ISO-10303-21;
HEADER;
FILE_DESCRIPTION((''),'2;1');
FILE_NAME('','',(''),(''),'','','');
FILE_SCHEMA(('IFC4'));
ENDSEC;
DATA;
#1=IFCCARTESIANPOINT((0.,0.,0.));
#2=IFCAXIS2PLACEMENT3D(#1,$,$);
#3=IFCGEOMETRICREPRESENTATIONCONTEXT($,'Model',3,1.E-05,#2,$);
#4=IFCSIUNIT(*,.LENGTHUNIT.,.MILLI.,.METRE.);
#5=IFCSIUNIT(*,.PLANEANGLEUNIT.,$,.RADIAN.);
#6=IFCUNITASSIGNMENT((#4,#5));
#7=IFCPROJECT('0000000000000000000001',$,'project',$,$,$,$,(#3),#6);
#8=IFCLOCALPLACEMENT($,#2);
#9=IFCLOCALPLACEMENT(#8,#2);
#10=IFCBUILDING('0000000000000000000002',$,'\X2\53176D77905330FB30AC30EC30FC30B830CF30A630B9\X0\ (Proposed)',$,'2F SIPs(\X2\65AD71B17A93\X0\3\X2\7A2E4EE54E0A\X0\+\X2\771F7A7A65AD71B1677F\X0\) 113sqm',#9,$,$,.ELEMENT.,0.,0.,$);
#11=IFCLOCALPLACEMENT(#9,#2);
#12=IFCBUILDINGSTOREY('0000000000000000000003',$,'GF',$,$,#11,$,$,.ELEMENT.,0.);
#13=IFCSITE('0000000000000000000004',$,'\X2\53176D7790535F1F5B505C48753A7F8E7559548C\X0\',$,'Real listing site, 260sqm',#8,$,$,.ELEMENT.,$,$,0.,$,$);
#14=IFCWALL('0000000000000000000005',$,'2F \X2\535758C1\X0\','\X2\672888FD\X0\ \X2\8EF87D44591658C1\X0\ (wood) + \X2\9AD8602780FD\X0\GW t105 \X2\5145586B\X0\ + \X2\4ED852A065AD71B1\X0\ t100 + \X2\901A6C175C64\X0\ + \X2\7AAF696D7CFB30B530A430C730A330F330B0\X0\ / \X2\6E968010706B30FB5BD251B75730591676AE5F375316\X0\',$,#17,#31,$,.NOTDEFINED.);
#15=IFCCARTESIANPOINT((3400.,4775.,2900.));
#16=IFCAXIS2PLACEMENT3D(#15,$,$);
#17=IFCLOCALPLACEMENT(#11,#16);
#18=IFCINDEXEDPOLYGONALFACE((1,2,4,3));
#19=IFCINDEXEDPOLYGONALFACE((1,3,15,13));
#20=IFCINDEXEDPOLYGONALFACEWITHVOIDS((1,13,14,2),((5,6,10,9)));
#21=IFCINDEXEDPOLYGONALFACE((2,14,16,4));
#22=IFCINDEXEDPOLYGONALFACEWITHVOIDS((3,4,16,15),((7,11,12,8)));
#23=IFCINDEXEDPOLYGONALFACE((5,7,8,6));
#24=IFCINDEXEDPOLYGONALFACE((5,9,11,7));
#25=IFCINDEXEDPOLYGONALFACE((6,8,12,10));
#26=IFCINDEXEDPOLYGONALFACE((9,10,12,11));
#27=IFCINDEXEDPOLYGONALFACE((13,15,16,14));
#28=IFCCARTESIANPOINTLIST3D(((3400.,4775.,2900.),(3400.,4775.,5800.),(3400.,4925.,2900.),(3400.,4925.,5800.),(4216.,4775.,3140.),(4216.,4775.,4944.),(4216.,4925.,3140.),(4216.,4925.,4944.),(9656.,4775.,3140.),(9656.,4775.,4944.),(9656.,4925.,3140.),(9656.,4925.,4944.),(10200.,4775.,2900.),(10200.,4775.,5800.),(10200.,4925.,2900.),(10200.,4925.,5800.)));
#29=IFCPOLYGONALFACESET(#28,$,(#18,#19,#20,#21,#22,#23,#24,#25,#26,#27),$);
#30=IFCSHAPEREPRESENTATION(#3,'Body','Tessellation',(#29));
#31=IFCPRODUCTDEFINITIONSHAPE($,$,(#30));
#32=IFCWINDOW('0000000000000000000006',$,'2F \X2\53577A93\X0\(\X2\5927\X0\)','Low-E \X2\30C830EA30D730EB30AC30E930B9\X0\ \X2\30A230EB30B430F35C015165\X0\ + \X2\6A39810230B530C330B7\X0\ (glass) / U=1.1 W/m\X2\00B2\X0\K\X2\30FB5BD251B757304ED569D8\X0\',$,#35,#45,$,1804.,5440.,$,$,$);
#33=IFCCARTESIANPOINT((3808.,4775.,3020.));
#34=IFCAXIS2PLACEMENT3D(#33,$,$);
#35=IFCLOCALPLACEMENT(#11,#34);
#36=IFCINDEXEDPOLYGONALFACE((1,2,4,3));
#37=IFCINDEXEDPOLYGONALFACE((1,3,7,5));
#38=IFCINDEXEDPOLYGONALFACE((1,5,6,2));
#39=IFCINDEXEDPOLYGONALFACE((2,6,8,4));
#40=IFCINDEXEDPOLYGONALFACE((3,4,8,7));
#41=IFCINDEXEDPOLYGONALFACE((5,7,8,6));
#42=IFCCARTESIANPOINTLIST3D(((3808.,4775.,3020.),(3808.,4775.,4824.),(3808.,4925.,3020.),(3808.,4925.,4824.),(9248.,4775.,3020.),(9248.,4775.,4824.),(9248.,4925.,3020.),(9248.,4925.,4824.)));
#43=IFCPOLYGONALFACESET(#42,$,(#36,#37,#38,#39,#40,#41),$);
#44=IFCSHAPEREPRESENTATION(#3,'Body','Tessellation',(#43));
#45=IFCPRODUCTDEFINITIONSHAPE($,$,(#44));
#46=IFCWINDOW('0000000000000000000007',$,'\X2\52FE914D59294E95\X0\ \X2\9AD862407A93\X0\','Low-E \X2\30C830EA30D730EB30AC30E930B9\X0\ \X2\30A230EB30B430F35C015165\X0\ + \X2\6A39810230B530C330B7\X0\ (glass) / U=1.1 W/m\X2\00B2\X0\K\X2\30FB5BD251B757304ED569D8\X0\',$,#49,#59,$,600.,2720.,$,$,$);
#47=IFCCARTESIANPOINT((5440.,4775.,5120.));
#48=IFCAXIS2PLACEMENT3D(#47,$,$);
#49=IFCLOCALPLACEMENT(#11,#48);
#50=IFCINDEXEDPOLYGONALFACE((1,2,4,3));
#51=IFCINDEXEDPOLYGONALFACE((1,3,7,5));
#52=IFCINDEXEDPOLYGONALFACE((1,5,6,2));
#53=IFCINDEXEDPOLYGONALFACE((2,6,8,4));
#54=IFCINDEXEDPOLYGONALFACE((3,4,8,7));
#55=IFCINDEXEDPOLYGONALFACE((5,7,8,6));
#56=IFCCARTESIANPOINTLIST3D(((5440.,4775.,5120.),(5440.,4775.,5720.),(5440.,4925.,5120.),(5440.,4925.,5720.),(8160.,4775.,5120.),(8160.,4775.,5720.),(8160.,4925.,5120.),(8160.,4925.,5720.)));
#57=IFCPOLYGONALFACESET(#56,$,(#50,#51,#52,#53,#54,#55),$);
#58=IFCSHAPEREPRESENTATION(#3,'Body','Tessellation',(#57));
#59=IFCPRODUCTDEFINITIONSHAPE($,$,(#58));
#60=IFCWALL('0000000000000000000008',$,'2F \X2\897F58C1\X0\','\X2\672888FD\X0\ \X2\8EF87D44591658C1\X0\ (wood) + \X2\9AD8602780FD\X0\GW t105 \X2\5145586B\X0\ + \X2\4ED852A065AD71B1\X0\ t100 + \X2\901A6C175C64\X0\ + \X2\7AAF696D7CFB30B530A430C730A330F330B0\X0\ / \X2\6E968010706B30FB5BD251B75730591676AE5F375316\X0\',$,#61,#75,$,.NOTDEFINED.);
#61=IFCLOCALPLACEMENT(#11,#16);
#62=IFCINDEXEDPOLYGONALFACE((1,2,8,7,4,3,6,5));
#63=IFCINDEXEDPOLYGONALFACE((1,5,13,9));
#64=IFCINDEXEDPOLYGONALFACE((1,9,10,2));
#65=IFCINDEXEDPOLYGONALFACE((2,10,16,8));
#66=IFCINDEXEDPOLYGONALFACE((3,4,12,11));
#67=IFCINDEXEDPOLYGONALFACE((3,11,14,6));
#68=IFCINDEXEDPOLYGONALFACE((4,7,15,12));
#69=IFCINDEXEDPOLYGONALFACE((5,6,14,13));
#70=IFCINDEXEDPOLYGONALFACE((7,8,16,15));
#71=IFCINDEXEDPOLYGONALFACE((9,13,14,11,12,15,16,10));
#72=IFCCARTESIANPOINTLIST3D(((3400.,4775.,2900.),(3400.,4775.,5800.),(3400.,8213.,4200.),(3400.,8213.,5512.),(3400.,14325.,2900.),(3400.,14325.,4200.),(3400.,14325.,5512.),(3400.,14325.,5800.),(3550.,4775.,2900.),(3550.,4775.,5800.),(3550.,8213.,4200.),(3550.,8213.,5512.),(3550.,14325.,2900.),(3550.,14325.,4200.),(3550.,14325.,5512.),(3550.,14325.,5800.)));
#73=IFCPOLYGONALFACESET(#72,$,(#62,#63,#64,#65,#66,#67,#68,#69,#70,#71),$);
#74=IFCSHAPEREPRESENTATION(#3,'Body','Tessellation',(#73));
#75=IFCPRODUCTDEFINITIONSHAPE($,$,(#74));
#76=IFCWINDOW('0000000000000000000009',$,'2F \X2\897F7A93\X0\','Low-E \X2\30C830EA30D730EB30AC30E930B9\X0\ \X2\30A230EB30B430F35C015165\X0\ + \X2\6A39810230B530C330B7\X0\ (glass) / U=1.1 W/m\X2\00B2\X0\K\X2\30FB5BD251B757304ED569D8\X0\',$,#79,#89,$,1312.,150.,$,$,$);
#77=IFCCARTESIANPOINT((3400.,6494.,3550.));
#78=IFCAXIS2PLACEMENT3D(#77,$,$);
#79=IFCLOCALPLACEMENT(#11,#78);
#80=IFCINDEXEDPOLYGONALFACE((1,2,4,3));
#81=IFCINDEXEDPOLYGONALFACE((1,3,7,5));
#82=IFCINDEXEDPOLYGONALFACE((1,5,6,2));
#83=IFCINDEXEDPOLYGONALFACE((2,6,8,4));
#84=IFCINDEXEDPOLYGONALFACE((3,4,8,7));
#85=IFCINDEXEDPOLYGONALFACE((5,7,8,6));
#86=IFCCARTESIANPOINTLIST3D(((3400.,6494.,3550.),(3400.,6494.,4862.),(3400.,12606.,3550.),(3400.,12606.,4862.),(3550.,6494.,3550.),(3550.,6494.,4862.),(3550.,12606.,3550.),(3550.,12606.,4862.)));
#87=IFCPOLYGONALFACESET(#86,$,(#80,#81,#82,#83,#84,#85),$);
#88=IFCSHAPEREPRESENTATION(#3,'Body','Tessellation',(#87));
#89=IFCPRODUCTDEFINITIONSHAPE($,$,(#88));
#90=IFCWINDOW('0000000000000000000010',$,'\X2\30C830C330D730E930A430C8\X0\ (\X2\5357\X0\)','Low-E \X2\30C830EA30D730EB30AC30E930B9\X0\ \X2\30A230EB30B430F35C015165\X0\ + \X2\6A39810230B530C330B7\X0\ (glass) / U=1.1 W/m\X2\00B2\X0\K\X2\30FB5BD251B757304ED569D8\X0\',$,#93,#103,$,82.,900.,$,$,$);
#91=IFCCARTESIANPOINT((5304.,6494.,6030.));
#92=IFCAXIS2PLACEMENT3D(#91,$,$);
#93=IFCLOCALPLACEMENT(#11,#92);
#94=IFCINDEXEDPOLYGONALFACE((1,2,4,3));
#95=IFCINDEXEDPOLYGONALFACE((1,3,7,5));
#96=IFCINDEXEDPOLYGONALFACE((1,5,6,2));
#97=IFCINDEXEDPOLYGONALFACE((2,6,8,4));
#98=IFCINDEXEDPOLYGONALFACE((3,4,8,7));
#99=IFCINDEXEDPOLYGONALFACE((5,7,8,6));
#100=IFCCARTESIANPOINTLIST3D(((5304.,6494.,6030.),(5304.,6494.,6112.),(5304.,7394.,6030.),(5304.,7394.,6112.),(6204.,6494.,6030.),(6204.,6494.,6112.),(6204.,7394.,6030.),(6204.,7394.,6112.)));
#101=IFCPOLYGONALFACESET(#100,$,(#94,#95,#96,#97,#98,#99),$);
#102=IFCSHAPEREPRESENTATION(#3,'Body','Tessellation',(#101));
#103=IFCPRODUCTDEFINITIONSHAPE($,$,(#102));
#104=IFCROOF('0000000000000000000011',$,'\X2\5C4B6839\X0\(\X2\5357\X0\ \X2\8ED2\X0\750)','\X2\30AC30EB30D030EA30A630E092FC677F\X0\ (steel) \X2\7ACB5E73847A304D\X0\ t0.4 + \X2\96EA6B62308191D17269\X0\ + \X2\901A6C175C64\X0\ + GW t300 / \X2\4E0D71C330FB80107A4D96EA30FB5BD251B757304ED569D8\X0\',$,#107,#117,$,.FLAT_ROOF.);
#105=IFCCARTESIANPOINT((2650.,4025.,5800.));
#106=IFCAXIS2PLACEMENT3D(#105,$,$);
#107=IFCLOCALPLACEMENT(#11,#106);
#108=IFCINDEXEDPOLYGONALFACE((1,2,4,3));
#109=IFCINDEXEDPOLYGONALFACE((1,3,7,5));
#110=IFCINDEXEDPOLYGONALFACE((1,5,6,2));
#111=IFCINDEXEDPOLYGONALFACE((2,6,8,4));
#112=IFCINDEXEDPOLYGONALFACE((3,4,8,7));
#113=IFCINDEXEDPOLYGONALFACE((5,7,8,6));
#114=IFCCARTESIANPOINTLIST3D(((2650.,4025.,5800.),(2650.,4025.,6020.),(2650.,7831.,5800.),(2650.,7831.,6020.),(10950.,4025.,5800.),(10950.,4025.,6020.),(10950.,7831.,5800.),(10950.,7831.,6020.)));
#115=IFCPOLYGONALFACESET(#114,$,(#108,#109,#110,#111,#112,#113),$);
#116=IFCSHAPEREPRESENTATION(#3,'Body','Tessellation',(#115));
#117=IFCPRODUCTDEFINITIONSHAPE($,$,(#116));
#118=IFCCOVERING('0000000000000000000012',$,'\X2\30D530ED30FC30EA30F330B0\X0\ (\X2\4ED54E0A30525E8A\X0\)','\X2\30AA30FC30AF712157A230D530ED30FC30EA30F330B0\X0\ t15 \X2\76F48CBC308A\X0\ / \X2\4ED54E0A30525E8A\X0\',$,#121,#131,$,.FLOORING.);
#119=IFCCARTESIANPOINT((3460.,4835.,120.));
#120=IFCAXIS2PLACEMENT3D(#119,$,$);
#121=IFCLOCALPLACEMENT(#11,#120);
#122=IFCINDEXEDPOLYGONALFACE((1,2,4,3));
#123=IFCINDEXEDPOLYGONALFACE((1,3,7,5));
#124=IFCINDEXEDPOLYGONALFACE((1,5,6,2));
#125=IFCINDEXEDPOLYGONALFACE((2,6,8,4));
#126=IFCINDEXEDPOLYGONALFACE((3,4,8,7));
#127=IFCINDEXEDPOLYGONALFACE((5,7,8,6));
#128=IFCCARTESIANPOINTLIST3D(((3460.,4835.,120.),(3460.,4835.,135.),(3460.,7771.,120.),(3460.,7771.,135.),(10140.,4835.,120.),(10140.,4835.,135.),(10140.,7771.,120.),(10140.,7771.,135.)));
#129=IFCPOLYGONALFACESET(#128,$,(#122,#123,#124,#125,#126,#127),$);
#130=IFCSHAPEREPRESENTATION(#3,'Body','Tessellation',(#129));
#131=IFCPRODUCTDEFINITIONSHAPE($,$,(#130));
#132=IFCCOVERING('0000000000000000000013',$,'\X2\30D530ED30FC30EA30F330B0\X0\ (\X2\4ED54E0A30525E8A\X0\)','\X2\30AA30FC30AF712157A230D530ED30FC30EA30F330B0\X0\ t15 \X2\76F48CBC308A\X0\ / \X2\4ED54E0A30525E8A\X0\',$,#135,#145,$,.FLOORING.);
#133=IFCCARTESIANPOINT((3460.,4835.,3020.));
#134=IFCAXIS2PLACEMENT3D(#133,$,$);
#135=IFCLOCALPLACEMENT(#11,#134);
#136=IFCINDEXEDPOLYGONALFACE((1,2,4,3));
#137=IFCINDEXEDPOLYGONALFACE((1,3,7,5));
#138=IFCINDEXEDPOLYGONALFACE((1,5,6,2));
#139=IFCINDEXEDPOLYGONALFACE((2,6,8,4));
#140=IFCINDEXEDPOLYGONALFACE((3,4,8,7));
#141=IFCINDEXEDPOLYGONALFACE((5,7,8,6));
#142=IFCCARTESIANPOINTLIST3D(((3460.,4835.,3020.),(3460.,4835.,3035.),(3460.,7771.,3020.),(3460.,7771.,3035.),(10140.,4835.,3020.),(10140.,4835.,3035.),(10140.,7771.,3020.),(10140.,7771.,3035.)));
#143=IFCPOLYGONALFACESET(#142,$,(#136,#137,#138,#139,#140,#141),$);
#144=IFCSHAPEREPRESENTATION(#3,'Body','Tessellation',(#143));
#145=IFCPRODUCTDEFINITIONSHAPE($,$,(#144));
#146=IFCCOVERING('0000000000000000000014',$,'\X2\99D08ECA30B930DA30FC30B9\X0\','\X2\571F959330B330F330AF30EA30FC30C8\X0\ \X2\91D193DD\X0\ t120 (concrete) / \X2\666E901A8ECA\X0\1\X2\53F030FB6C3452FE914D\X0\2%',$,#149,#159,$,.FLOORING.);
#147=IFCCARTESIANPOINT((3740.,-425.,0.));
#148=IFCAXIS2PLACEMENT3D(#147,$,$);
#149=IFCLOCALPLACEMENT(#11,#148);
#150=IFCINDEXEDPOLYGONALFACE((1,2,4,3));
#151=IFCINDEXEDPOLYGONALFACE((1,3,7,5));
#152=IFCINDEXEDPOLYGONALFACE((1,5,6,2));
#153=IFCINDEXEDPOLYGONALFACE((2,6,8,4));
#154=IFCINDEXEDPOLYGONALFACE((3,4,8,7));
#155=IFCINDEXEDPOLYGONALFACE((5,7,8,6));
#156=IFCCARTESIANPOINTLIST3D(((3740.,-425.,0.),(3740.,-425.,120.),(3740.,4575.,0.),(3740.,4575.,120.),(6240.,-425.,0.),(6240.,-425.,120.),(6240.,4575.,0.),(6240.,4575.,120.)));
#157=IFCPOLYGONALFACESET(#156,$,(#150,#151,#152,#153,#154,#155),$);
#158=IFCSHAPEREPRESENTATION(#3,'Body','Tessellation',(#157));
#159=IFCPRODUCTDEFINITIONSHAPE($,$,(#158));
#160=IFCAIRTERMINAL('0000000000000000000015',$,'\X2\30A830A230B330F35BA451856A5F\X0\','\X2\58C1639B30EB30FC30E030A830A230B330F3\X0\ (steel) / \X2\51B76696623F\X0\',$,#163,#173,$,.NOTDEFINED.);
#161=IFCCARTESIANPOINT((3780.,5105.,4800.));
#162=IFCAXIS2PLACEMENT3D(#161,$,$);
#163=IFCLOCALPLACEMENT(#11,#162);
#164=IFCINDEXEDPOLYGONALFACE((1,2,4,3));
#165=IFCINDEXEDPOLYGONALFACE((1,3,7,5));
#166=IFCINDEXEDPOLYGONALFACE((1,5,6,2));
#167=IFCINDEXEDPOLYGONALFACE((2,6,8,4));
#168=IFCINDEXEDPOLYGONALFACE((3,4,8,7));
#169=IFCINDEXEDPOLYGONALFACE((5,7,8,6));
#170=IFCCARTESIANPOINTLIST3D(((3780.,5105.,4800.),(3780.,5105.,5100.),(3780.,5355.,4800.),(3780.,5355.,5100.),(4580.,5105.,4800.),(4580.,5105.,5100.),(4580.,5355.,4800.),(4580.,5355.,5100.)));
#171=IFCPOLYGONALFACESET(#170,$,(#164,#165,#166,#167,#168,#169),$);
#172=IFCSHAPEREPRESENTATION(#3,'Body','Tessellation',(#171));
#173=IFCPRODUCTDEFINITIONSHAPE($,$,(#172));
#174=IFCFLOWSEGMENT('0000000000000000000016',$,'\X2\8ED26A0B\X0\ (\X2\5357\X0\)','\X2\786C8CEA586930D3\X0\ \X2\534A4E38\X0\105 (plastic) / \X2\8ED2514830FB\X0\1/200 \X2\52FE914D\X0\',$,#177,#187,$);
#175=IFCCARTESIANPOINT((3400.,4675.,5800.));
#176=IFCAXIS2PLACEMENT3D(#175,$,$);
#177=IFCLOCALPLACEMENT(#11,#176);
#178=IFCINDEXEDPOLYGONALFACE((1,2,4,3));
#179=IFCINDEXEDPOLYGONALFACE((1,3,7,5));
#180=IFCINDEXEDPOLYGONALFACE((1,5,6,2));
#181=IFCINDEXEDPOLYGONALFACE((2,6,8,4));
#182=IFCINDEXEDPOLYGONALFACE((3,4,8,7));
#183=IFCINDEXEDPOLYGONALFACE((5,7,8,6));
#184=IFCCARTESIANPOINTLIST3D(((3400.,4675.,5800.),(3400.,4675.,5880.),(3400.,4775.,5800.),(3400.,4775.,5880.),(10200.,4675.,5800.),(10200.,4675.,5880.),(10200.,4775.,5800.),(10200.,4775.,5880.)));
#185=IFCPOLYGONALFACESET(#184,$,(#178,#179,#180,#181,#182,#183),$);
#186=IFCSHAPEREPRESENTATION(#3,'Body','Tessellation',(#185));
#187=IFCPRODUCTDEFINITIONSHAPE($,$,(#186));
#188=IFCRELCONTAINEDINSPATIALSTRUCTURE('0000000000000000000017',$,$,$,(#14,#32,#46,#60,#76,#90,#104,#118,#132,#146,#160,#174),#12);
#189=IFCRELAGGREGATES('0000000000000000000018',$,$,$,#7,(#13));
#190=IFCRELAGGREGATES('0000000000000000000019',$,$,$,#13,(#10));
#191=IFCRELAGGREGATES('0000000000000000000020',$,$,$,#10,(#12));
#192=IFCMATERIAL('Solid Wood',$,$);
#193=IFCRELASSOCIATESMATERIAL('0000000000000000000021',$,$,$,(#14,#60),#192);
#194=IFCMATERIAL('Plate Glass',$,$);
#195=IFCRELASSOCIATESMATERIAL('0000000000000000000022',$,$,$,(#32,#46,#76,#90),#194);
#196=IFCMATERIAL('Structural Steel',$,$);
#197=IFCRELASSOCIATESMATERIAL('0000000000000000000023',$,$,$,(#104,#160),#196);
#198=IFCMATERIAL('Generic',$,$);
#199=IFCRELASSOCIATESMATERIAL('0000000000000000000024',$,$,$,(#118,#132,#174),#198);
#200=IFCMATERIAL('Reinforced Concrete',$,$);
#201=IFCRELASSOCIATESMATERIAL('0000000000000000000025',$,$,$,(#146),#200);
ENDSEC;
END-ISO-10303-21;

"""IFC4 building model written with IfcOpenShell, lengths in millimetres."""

from ifc_helpers import new_model, si_unit, frame, frame_2d, origin, place, context, project, spatial, rectangle, extrude, material, element, fill, save


model = new_model("IFC4")

# Units and contexts
model_context = context("Model", 3, precision=1e-05, world=origin())
ifc_project = project(units=[si_unit("LENGTHUNIT", "METRE", prefix="MILLI"), si_unit("PLANEANGLEUNIT", "RADIAN")], contexts=[model_context])

# Site, building, storey
site_placement = place(None, origin())
site = spatial("IfcSite", under=ifc_project, at=site_placement, Name="北海道弟子屈町美留和", ObjectType="Real listing site, 260sqm", CompositionType="ELEMENT", RefElevation=0.0)
building_placement = place(site_placement, origin())
building = spatial("IfcBuilding", under=site, at=building_placement, Name="北海道・ガレージハウス (Proposed)", ObjectType="2F SIPs(断熱窓3種以上+真空断熱板) 113sqm", CompositionType="ELEMENT", ElevationOfRefHeight=0.0, ElevationOfTerrain=0.0)
storey_placement = place(building_placement, origin())
storey = spatial("IfcBuildingStorey", under=building, at=storey_placement, Name="GF", CompositionType="ELEMENT", Elevation=0.0)

# Shared definitions
ifc_material_1 = material(Name="Solid Wood")

# Shared definitions
ifc_material_2 = material(Name="Reinforced Concrete")

# Shared definitions
ifc_material_3 = material(Name="Plate Glass")

# Wall, openings, windows
wall_1_placement = place(storey_placement, frame((3400.0, 4775.0, 2900.0)))
wall_1 = element("IfcWall", 1, at=wall_1_placement, inside=storey, material=ifc_material_1, Name="2F 南壁", Description="木製 軸組外壁 (wood) + 高性能GW t105 充填 + 付加断熱 t100 + 通気層 + 窯業系サイディング / 準耐火・寒冷地外皮強化", PredefinedType="NOTDEFINED", context=model_context, shape_type="SweptSolid", body=[
    extrude(rectangle(XDim=6800.0, YDim=150.0, at=frame_2d((3400.0, 75.0))), frame((3400.0, 4775.0, 2900.0)), (0.0, 0.0, 1.0), 2900.0),
])
opening_1_placement = place(storey_placement, frame((3808.0, 4775.0, 3020.0)))
opening_1 = element("IfcOpeningElement", 2, at=opening_1_placement, cuts=wall_1, PredefinedType="NOTDEFINED", context=model_context, shape_type="SweptSolid", body=[
    extrude(rectangle(XDim=5440.0, YDim=150.0, at=frame_2d((2720.0, 75.0))), frame((3808.0, 4775.0, 3020.0)), (0.0, 0.0, 1.0), 1804.0),
])
opening_2_placement = place(storey_placement, frame((5440.0, 4775.0, 5120.0)))
opening_2 = element("IfcOpeningElement", 3, at=opening_2_placement, cuts=wall_1, PredefinedType="NOTDEFINED", context=model_context, shape_type="SweptSolid", body=[
    extrude(rectangle(XDim=2720.0, YDim=150.0, at=frame_2d((1360.0, 75.0))), frame((5440.0, 4775.0, 5120.0)), (0.0, 0.0, 1.0), 600.0),
])
window_1_placement = place(storey_placement, frame((3808.0, 4775.0, 3020.0)))
window_1 = element("IfcWindow", 4, at=window_1_placement, inside=storey, material=ifc_material_3, Name="2F 南窓(大)", Description="Low-E トリプルガラス アルゴン封入 + 樹脂サッシ (glass) / U=1.1 W/m²K・寒冷地仕様", OverallHeight=1804.0, OverallWidth=5440.0, context=model_context, shape_type="SweptSolid", body=[
    extrude(rectangle(XDim=5440.0, YDim=150.0, at=frame_2d((2720.0, 75.0))), frame((3808.0, 4775.0, 3020.0)), (0.0, 0.0, 1.0), 1804.0),
])
fill(opening_1, window_1)
window_2_placement = place(storey_placement, frame((5440.0, 4775.0, 5120.0)))
window_2 = element("IfcWindow", 5, at=window_2_placement, inside=storey, material=ifc_material_3, Name="勾配天井 高所窓", Description="Low-E トリプルガラス アルゴン封入 + 樹脂サッシ (glass) / U=1.1 W/m²K・寒冷地仕様", OverallHeight=600.0, OverallWidth=2720.0, context=model_context, shape_type="SweptSolid", body=[
    extrude(rectangle(XDim=2720.0, YDim=150.0, at=frame_2d((1360.0, 75.0))), frame((5440.0, 4775.0, 5120.0)), (0.0, 0.0, 1.0), 600.0),
])
fill(opening_2, window_2)

# Wall, opening, window
wall_2_placement = place(storey_placement, frame((3400.0, 4775.0, 2900.0)))
wall_2 = element("IfcWall", 6, at=wall_2_placement, inside=storey, material=ifc_material_1, Name="2F 西壁", Description="木製 軸組外壁 (wood) + 高性能GW t105 充填 + 付加断熱 t100 + 通気層 + 窯業系サイディング / 準耐火・寒冷地外皮強化", PredefinedType="NOTDEFINED", context=model_context, shape_type="SweptSolid", body=[
    extrude(rectangle(XDim=150.0, YDim=9550.0, at=frame_2d((75.0, 4775.0))), frame((3400.0, 4775.0, 2900.0)), (0.0, 0.0, 1.0), 2900.0),
])
opening_3_placement = place(storey_placement, frame((3400.0, 6494.0, 3550.0)))
opening_3 = element("IfcOpeningElement", 7, at=opening_3_placement, cuts=wall_2, PredefinedType="NOTDEFINED", context=model_context, shape_type="SweptSolid", body=[
    extrude(rectangle(XDim=150.0, YDim=6112.0, at=frame_2d((75.0, 3056.0))), frame((3400.0, 6494.0, 3550.0)), (0.0, 0.0, 1.0), 1312.0),
])
window_3_placement = place(storey_placement, frame((3400.0, 6494.0, 3550.0)))
window_3 = element("IfcWindow", 8, at=window_3_placement, inside=storey, material=ifc_material_3, Name="2F 西窓", Description="Low-E トリプルガラス アルゴン封入 + 樹脂サッシ (glass) / U=1.1 W/m²K・寒冷地仕様", OverallHeight=1312.0, OverallWidth=150.0, context=model_context, shape_type="SweptSolid", body=[
    extrude(rectangle(XDim=150.0, YDim=6112.0, at=frame_2d((75.0, 3056.0))), frame((3400.0, 6494.0, 3550.0)), (0.0, 0.0, 1.0), 1312.0),
])
fill(opening_3, window_3)

# Window
window_4_placement = place(storey_placement, frame((5304.0, 6494.0, 6030.0)))
element("IfcWindow", 9, at=window_4_placement, inside=storey, material=ifc_material_3, Name="トップライト (南)", Description="Low-E トリプルガラス アルゴン封入 + 樹脂サッシ (glass) / U=1.1 W/m²K・寒冷地仕様", OverallHeight=82.0, OverallWidth=900.0, context=model_context, shape_type="SweptSolid", body=[
    extrude(rectangle(XDim=900.0, YDim=900.0, at=frame_2d((450.0, 450.0))), frame((5304.0, 6494.0, 6030.0)), (0.0, 0.0, 1.0), 82.0),
])

# Roof
ifc_material_4 = material(Name="Structural Steel")
for number, where, name in (
    (10, (2650.0, 4025.0, 5800.0), "屋根(南 軒750)"),
):
    element("IfcRoof", number, at=place(storey_placement, frame(where)), inside=storey, material=ifc_material_4, Name=name, Description="ガルバリウム鋼板 (steel) 立平葺き t0.4 + 雪止め金物 + 通気層 + GW t300 / 不燃・耐積雪・寒冷地仕様", PredefinedType="FLAT_ROOF", context=model_context, shape_type="SweptSolid", body=[
        extrude(rectangle(XDim=8300.0, YDim=3806.0, at=frame_2d((4150.0, 1903.0))), frame((2650.0, 4025.0, 5800.0)), (0.0, 0.0, 1.0), 220.0),
    ])

# Coverings
ifc_material_5 = material(Name="Generic")
covering_1_placement = place(storey_placement, frame((3460.0, 4835.0, 120.0)))
element("IfcCovering", 11, at=covering_1_placement, inside=storey, material=ifc_material_5, Name="フローリング (仕上げ床)", Description="オーク無垢フローリング t15 直貼り / 仕上げ床", PredefinedType="FLOORING", context=model_context, shape_type="SweptSolid", body=[
    extrude(rectangle(XDim=6680.0, YDim=2936.0, at=frame_2d((3340.0, 1468.0))), frame((3460.0, 4835.0, 120.0)), (0.0, 0.0, 1.0), 15.0),
])
covering_2_placement = place(storey_placement, frame((3460.0, 4835.0, 3020.0)))
element("IfcCovering", 12, at=covering_2_placement, inside=storey, material=ifc_material_5, Name="フローリング (仕上げ床)", Description="オーク無垢フローリング t15 直貼り / 仕上げ床", PredefinedType="FLOORING", context=model_context, shape_type="SweptSolid", body=[
    extrude(rectangle(XDim=6680.0, YDim=2936.0, at=frame_2d((3340.0, 1468.0))), frame((3460.0, 4835.0, 3020.0)), (0.0, 0.0, 1.0), 15.0),
])
covering_3_placement = place(storey_placement, frame((3740.0, -425.0, 0.0)))
element("IfcCovering", 13, at=covering_3_placement, inside=storey, material=ifc_material_2, Name="駐車スペース", Description="土間コンクリート 金鏝 t120 (concrete) / 普通車1台・水勾配2%", PredefinedType="FLOORING", context=model_context, shape_type="SweptSolid", body=[
    extrude(rectangle(XDim=2500.0, YDim=5000.0, at=frame_2d((1250.0, 2500.0))), frame((3740.0, -425.0, 0.0)), (0.0, 0.0, 1.0), 120.0),
])

# Air terminal
air_terminal_placement = place(storey_placement, frame((3780.0, 5105.0, 4800.0)))
element("IfcAirTerminal", 14, at=air_terminal_placement, inside=storey, material=ifc_material_4, Name="エアコン室内機", Description="壁掛ルームエアコン (steel) / 冷暖房", PredefinedType="NOTDEFINED", context=model_context, shape_type="SweptSolid", body=[
    extrude(rectangle(XDim=800.0, YDim=250.0, at=frame_2d((400.0, 125.0))), frame((3780.0, 5105.0, 4800.0)), (0.0, 0.0, 1.0), 300.0),
])

# Flow segment
flow_segment_1_placement = place(storey_placement, frame((3400.0, 4675.0, 5800.0)))
element("IfcFlowSegment", 15, at=flow_segment_1_placement, inside=storey, material=ifc_material_5, Name="軒樋 (南)", Description="硬質塩ビ 半丸105 (plastic) / 軒先・1/200 勾配", context=model_context, shape_type="SweptSolid", body=[
    extrude(rectangle(XDim=6800.0, YDim=100.0, at=frame_2d((3400.0, 50.0))), frame((3400.0, 4675.0, 5800.0)), (0.0, 0.0, 1.0), 80.0),
])

save(model, "model.ifc")
